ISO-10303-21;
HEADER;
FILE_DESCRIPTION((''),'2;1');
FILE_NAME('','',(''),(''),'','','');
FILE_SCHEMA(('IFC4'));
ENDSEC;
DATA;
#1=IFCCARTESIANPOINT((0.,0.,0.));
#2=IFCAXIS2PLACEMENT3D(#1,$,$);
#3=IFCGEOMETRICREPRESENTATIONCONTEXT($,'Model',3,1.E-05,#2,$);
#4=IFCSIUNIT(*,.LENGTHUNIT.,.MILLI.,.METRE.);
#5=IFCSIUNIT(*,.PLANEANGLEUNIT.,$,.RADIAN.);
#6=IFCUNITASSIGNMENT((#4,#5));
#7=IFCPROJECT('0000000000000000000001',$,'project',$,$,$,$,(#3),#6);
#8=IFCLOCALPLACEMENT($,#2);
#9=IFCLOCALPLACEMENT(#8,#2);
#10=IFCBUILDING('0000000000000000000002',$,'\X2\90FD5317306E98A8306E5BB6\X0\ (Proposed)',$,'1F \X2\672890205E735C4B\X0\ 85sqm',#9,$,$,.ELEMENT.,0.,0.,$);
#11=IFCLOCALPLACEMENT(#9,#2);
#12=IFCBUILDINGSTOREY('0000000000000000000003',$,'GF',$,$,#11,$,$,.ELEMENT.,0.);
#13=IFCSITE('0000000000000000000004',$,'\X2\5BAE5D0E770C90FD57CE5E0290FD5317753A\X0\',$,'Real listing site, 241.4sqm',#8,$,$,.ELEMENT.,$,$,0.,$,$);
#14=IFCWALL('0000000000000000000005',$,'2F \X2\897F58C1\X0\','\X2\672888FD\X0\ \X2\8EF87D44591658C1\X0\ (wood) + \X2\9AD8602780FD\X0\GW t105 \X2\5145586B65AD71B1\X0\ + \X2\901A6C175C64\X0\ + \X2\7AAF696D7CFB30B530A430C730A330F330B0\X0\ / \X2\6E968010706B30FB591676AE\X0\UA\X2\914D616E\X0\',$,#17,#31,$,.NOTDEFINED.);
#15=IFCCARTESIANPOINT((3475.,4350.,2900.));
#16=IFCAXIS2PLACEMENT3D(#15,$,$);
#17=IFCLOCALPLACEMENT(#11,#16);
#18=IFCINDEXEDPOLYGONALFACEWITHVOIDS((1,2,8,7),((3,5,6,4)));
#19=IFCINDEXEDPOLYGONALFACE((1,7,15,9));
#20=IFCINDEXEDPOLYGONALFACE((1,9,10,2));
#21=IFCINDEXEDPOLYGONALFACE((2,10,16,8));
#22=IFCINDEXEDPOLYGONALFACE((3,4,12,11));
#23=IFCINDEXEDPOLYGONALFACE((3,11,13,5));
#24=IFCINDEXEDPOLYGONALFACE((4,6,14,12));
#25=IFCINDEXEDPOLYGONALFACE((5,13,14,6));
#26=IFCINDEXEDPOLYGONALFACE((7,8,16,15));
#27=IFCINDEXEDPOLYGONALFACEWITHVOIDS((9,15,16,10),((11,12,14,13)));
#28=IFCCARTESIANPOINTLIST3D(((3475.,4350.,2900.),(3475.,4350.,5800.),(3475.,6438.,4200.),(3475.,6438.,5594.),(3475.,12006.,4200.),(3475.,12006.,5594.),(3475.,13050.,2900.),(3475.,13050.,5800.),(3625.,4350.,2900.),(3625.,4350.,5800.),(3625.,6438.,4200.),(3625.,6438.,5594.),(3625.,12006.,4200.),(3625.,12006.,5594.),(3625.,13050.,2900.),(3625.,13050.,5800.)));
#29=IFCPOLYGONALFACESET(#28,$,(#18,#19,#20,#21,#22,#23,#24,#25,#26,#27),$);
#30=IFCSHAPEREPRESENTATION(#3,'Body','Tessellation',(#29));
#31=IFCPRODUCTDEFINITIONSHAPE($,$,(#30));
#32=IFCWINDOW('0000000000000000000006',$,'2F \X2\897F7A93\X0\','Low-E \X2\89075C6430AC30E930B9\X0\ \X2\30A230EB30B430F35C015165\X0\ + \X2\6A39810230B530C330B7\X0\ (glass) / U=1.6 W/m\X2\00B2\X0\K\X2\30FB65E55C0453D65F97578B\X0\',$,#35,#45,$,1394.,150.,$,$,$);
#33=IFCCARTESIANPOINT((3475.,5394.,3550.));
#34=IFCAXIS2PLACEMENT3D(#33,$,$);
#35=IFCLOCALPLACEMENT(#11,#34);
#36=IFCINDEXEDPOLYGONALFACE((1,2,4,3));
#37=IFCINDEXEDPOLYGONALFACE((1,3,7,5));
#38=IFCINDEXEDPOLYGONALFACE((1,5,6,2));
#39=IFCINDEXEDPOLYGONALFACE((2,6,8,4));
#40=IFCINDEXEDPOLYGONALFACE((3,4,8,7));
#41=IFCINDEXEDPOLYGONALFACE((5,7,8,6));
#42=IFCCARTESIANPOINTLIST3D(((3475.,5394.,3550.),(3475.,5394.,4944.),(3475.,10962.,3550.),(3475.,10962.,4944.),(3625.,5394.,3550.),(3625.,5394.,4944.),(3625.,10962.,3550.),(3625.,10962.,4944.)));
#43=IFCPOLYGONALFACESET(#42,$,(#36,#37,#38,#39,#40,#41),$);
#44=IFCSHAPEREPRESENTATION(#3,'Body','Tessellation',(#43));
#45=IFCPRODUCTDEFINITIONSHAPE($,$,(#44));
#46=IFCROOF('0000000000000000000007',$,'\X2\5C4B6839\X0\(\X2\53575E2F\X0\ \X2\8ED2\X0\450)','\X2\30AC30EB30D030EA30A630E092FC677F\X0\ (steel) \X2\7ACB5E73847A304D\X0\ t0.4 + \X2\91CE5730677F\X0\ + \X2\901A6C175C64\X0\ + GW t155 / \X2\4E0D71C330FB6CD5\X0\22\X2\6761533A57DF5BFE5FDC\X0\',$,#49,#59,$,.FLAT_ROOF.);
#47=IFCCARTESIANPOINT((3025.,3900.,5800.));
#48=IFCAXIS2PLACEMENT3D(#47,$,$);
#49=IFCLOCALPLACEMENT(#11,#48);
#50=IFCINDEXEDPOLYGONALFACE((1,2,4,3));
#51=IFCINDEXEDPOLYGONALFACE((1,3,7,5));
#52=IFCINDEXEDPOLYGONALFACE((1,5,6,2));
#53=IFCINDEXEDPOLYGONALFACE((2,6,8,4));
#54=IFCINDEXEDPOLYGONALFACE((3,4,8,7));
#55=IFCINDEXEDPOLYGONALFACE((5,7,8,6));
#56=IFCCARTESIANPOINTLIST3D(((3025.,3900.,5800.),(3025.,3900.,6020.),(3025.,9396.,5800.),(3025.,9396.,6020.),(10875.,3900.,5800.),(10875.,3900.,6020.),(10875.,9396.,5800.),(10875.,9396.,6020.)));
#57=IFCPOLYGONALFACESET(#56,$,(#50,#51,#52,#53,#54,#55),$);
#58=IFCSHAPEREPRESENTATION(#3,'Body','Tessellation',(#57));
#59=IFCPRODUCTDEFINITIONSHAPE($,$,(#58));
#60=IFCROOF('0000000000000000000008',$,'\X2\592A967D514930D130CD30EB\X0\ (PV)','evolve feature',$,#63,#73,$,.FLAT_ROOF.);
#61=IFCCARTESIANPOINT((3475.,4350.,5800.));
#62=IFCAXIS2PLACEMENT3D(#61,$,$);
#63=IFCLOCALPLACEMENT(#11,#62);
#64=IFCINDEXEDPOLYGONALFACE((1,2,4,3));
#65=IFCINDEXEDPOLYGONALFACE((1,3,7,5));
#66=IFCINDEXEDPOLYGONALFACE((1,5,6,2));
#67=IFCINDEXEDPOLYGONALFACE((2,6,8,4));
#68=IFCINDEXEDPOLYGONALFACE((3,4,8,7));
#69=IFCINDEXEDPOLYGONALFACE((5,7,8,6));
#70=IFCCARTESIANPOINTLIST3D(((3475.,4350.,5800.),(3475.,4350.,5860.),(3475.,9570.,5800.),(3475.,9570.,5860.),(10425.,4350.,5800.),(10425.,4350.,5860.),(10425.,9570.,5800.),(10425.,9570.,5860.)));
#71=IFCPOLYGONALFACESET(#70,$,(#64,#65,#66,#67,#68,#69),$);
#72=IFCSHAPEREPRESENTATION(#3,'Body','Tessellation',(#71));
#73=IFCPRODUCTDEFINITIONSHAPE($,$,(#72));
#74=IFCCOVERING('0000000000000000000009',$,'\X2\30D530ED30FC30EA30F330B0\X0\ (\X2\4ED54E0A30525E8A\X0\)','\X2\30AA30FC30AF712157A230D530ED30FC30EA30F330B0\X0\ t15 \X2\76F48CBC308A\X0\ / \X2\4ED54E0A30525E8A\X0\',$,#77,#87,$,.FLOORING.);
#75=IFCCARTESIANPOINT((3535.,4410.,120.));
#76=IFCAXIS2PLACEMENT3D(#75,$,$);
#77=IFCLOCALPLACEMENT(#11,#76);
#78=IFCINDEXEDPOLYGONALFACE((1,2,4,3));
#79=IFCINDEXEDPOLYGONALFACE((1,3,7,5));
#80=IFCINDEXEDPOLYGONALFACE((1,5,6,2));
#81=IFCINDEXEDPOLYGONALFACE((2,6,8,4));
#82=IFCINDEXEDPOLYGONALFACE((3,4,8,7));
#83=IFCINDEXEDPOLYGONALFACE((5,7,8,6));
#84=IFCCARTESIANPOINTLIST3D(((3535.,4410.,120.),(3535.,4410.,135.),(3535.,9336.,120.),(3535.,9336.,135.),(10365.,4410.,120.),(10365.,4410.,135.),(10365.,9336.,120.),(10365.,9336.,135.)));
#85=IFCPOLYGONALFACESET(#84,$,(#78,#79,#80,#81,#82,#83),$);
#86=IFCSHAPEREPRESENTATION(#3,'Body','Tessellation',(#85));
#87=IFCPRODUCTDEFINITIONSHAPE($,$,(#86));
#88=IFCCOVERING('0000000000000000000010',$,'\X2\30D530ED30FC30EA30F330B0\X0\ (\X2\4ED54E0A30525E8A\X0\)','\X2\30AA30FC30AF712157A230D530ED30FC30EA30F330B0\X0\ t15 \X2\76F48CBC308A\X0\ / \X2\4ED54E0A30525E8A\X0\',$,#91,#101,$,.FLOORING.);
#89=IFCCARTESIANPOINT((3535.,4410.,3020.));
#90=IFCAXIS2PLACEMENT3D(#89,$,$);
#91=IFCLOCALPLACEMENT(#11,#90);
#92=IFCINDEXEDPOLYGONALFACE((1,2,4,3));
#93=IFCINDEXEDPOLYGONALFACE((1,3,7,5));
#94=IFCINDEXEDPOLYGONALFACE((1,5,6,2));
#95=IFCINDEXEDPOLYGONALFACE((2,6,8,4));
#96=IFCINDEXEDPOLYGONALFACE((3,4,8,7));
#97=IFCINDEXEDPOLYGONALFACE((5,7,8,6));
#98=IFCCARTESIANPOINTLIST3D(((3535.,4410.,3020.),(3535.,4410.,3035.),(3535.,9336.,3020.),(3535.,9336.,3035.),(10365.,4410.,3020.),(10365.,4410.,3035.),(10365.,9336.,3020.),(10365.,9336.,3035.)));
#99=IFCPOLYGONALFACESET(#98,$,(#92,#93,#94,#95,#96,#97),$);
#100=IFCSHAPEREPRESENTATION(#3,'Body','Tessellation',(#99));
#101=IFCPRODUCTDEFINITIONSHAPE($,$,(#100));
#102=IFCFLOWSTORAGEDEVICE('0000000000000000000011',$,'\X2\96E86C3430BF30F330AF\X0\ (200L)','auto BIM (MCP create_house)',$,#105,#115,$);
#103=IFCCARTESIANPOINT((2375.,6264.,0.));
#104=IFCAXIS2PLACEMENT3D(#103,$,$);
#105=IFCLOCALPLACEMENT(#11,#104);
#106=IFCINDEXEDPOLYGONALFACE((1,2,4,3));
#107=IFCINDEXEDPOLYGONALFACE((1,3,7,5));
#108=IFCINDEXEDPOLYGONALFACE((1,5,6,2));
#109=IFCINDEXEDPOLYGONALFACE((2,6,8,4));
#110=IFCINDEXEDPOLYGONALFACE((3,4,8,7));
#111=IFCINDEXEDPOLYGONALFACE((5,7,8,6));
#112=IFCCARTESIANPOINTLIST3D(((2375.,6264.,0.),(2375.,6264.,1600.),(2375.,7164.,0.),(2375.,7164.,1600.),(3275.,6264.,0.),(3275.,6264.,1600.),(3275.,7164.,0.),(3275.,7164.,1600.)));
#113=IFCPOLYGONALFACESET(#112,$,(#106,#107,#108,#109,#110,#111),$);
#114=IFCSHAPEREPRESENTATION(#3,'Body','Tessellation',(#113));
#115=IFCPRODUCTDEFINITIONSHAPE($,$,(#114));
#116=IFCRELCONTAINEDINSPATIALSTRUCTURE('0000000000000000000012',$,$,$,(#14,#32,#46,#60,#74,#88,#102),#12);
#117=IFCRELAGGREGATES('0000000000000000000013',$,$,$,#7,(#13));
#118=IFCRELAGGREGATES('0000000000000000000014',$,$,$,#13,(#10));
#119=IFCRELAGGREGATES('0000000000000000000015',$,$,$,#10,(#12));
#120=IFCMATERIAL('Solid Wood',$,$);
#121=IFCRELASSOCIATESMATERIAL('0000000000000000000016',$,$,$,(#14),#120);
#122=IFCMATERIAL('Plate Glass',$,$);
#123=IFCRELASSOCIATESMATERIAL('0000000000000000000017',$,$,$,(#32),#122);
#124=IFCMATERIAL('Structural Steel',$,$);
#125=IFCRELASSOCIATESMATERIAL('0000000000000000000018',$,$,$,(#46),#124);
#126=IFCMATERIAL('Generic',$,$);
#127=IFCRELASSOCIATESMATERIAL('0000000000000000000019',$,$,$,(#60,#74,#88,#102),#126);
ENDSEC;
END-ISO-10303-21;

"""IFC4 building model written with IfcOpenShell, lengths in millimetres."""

from ifc_helpers import new_model, si_unit, frame, frame_2d, origin, place, context, project, spatial, rectangle, extrude, material, element, fill, save


model = new_model("IFC4")

# Units and contexts
model_context = context("Model", 3, precision=1e-05, world=origin())
ifc_project = project(units=[si_unit("LENGTHUNIT", "METRE", prefix="MILLI"), si_unit("PLANEANGLEUNIT", "RADIAN")], contexts=[model_context])

# Site, building, storey
site_placement = place(None, origin())
site = spatial("IfcSite", under=ifc_project, at=site_placement, Name="宮崎県都城市都北町", ObjectType="Real listing site, 241.4sqm", CompositionType="ELEMENT", RefElevation=0.0)
building_placement = place(site_placement, origin())
building = spatial("IfcBuilding", under=site, at=building_placement, Name="都北の風の家 (Proposed)", ObjectType="1F 木造平屋 85sqm", CompositionType="ELEMENT", ElevationOfRefHeight=0.0, ElevationOfTerrain=0.0)
storey_placement = place(building_placement, origin())
storey = spatial("IfcBuildingStorey", under=building, at=storey_placement, Name="GF", CompositionType="ELEMENT", Elevation=0.0)

# Shared definitions
ifc_material_1 = material(Name="Solid Wood")
ifc_material_2 = material(Name="Generic")

# Shared definitions
ifc_material_3 = material(Name="Plate Glass")

# Wall, opening, window
wall_1_placement = place(storey_placement, frame((3475.0, 4350.0, 2900.0)))
wall_1 = element("IfcWall", 1, at=wall_1_placement, inside=storey, material=ifc_material_1, Name="2F 西壁", Description="木製 軸組外壁 (wood) + 高性能GW t105 充填断熱 + 通気層 + 窯業系サイディング / 準耐火・外皮UA配慮", PredefinedType="NOTDEFINED", context=model_context, shape_type="SweptSolid", body=[
    extrude(rectangle(XDim=150.0, YDim=8700.0, at=frame_2d((75.0, 4350.0))), frame((3475.0, 4350.0, 2900.0)), (0.0, 0.0, 1.0), 2900.0),
])
opening_1_placement = place(storey_placement, frame((3475.0, 5394.0, 3550.0)))
opening_1 = element("IfcOpeningElement", 2, at=opening_1_placement, cuts=wall_1, PredefinedType="NOTDEFINED", context=model_context, shape_type="SweptSolid", body=[
    extrude(rectangle(XDim=150.0, YDim=5568.0, at=frame_2d((75.0, 2784.0))), frame((3475.0, 5394.0, 3550.0)), (0.0, 0.0, 1.0), 1394.0),
])
window_1_placement = place(storey_placement, frame((3475.0, 5394.0, 3550.0)))
window_1 = element("IfcWindow", 3, at=window_1_placement, inside=storey, material=ifc_material_3, Name="2F 西窓", Description="Low-E 複層ガラス アルゴン封入 + 樹脂サッシ (glass) / U=1.6 W/m²K・日射取得型", OverallHeight=1394.0, OverallWidth=150.0, context=model_context, shape_type="SweptSolid", body=[
    extrude(rectangle(XDim=150.0, YDim=5568.0, at=frame_2d((75.0, 2784.0))), frame((3475.0, 5394.0, 3550.0)), (0.0, 0.0, 1.0), 1394.0),
])
fill(opening_1, window_1)

# Roofs
ifc_material_4 = material(Name="Structural Steel")
for number, where, name in (
    (4, (3025.0, 3900.0, 5800.0), "屋根(南帯 軒450)"),
):
    element("IfcRoof", number, at=place(storey_placement, frame(where)), inside=storey, material=ifc_material_4, Name=name, Description="ガルバリウム鋼板 (steel) 立平葺き t0.4 + 野地板 + 通気層 + GW t155 / 不燃・法22条区域対応", PredefinedType="FLAT_ROOF", context=model_context, shape_type="SweptSolid", body=[
        extrude(rectangle(XDim=7850.0, YDim=5496.0, at=frame_2d((3925.0, 2748.0))), frame((3025.0, 3900.0, 5800.0)), (0.0, 0.0, 1.0), 220.0),
    ])
roof_placement = place(storey_placement, frame((3475.0, 4350.0, 5800.0)))
element("IfcRoof", 5, at=roof_placement, inside=storey, material=ifc_material_2, Name="太陽光パネル (PV)", Description="evolve feature", PredefinedType="FLAT_ROOF", context=model_context, shape_type="SweptSolid", body=[
    extrude(rectangle(XDim=6950.0, YDim=5220.0, at=frame_2d((3475.0, 2610.0))), frame((3475.0, 4350.0, 5800.0)), (0.0, 0.0, 1.0), 60.0),
])

# Coverings
covering_1_placement = place(storey_placement, frame((3535.0, 4410.0, 120.0)))
element("IfcCovering", 6, at=covering_1_placement, inside=storey, material=ifc_material_2, Name="フローリング (仕上げ床)", Description="オーク無垢フローリング t15 直貼り / 仕上げ床", PredefinedType="FLOORING", context=model_context, shape_type="SweptSolid", body=[
    extrude(rectangle(XDim=6830.0, YDim=4926.0, at=frame_2d((3415.0, 2463.0))), frame((3535.0, 4410.0, 120.0)), (0.0, 0.0, 1.0), 15.0),
])
covering_2_placement = place(storey_placement, frame((3535.0, 4410.0, 3020.0)))
element("IfcCovering", 7, at=covering_2_placement, inside=storey, material=ifc_material_2, Name="フローリング (仕上げ床)", Description="オーク無垢フローリング t15 直貼り / 仕上げ床", PredefinedType="FLOORING", context=model_context, shape_type="SweptSolid", body=[
    extrude(rectangle(XDim=6830.0, YDim=4926.0, at=frame_2d((3415.0, 2463.0))), frame((3535.0, 4410.0, 3020.0)), (0.0, 0.0, 1.0), 15.0),
])

# Flow storage device
flow_storage_device_placement = place(storey_placement, frame((2375.0, 6264.0, 0.0)))
element("IfcFlowStorageDevice", 8, at=flow_storage_device_placement, inside=storey, material=ifc_material_2, Name="雨水タンク (200L)", Description="auto BIM (MCP create_house)", context=model_context, shape_type="SweptSolid", body=[
    extrude(rectangle(XDim=900.0, YDim=900.0, at=frame_2d((450.0, 450.0))), frame((2375.0, 6264.0, 0.0)), (0.0, 0.0, 1.0), 1600.0),
])

save(model, "model.ifc")
